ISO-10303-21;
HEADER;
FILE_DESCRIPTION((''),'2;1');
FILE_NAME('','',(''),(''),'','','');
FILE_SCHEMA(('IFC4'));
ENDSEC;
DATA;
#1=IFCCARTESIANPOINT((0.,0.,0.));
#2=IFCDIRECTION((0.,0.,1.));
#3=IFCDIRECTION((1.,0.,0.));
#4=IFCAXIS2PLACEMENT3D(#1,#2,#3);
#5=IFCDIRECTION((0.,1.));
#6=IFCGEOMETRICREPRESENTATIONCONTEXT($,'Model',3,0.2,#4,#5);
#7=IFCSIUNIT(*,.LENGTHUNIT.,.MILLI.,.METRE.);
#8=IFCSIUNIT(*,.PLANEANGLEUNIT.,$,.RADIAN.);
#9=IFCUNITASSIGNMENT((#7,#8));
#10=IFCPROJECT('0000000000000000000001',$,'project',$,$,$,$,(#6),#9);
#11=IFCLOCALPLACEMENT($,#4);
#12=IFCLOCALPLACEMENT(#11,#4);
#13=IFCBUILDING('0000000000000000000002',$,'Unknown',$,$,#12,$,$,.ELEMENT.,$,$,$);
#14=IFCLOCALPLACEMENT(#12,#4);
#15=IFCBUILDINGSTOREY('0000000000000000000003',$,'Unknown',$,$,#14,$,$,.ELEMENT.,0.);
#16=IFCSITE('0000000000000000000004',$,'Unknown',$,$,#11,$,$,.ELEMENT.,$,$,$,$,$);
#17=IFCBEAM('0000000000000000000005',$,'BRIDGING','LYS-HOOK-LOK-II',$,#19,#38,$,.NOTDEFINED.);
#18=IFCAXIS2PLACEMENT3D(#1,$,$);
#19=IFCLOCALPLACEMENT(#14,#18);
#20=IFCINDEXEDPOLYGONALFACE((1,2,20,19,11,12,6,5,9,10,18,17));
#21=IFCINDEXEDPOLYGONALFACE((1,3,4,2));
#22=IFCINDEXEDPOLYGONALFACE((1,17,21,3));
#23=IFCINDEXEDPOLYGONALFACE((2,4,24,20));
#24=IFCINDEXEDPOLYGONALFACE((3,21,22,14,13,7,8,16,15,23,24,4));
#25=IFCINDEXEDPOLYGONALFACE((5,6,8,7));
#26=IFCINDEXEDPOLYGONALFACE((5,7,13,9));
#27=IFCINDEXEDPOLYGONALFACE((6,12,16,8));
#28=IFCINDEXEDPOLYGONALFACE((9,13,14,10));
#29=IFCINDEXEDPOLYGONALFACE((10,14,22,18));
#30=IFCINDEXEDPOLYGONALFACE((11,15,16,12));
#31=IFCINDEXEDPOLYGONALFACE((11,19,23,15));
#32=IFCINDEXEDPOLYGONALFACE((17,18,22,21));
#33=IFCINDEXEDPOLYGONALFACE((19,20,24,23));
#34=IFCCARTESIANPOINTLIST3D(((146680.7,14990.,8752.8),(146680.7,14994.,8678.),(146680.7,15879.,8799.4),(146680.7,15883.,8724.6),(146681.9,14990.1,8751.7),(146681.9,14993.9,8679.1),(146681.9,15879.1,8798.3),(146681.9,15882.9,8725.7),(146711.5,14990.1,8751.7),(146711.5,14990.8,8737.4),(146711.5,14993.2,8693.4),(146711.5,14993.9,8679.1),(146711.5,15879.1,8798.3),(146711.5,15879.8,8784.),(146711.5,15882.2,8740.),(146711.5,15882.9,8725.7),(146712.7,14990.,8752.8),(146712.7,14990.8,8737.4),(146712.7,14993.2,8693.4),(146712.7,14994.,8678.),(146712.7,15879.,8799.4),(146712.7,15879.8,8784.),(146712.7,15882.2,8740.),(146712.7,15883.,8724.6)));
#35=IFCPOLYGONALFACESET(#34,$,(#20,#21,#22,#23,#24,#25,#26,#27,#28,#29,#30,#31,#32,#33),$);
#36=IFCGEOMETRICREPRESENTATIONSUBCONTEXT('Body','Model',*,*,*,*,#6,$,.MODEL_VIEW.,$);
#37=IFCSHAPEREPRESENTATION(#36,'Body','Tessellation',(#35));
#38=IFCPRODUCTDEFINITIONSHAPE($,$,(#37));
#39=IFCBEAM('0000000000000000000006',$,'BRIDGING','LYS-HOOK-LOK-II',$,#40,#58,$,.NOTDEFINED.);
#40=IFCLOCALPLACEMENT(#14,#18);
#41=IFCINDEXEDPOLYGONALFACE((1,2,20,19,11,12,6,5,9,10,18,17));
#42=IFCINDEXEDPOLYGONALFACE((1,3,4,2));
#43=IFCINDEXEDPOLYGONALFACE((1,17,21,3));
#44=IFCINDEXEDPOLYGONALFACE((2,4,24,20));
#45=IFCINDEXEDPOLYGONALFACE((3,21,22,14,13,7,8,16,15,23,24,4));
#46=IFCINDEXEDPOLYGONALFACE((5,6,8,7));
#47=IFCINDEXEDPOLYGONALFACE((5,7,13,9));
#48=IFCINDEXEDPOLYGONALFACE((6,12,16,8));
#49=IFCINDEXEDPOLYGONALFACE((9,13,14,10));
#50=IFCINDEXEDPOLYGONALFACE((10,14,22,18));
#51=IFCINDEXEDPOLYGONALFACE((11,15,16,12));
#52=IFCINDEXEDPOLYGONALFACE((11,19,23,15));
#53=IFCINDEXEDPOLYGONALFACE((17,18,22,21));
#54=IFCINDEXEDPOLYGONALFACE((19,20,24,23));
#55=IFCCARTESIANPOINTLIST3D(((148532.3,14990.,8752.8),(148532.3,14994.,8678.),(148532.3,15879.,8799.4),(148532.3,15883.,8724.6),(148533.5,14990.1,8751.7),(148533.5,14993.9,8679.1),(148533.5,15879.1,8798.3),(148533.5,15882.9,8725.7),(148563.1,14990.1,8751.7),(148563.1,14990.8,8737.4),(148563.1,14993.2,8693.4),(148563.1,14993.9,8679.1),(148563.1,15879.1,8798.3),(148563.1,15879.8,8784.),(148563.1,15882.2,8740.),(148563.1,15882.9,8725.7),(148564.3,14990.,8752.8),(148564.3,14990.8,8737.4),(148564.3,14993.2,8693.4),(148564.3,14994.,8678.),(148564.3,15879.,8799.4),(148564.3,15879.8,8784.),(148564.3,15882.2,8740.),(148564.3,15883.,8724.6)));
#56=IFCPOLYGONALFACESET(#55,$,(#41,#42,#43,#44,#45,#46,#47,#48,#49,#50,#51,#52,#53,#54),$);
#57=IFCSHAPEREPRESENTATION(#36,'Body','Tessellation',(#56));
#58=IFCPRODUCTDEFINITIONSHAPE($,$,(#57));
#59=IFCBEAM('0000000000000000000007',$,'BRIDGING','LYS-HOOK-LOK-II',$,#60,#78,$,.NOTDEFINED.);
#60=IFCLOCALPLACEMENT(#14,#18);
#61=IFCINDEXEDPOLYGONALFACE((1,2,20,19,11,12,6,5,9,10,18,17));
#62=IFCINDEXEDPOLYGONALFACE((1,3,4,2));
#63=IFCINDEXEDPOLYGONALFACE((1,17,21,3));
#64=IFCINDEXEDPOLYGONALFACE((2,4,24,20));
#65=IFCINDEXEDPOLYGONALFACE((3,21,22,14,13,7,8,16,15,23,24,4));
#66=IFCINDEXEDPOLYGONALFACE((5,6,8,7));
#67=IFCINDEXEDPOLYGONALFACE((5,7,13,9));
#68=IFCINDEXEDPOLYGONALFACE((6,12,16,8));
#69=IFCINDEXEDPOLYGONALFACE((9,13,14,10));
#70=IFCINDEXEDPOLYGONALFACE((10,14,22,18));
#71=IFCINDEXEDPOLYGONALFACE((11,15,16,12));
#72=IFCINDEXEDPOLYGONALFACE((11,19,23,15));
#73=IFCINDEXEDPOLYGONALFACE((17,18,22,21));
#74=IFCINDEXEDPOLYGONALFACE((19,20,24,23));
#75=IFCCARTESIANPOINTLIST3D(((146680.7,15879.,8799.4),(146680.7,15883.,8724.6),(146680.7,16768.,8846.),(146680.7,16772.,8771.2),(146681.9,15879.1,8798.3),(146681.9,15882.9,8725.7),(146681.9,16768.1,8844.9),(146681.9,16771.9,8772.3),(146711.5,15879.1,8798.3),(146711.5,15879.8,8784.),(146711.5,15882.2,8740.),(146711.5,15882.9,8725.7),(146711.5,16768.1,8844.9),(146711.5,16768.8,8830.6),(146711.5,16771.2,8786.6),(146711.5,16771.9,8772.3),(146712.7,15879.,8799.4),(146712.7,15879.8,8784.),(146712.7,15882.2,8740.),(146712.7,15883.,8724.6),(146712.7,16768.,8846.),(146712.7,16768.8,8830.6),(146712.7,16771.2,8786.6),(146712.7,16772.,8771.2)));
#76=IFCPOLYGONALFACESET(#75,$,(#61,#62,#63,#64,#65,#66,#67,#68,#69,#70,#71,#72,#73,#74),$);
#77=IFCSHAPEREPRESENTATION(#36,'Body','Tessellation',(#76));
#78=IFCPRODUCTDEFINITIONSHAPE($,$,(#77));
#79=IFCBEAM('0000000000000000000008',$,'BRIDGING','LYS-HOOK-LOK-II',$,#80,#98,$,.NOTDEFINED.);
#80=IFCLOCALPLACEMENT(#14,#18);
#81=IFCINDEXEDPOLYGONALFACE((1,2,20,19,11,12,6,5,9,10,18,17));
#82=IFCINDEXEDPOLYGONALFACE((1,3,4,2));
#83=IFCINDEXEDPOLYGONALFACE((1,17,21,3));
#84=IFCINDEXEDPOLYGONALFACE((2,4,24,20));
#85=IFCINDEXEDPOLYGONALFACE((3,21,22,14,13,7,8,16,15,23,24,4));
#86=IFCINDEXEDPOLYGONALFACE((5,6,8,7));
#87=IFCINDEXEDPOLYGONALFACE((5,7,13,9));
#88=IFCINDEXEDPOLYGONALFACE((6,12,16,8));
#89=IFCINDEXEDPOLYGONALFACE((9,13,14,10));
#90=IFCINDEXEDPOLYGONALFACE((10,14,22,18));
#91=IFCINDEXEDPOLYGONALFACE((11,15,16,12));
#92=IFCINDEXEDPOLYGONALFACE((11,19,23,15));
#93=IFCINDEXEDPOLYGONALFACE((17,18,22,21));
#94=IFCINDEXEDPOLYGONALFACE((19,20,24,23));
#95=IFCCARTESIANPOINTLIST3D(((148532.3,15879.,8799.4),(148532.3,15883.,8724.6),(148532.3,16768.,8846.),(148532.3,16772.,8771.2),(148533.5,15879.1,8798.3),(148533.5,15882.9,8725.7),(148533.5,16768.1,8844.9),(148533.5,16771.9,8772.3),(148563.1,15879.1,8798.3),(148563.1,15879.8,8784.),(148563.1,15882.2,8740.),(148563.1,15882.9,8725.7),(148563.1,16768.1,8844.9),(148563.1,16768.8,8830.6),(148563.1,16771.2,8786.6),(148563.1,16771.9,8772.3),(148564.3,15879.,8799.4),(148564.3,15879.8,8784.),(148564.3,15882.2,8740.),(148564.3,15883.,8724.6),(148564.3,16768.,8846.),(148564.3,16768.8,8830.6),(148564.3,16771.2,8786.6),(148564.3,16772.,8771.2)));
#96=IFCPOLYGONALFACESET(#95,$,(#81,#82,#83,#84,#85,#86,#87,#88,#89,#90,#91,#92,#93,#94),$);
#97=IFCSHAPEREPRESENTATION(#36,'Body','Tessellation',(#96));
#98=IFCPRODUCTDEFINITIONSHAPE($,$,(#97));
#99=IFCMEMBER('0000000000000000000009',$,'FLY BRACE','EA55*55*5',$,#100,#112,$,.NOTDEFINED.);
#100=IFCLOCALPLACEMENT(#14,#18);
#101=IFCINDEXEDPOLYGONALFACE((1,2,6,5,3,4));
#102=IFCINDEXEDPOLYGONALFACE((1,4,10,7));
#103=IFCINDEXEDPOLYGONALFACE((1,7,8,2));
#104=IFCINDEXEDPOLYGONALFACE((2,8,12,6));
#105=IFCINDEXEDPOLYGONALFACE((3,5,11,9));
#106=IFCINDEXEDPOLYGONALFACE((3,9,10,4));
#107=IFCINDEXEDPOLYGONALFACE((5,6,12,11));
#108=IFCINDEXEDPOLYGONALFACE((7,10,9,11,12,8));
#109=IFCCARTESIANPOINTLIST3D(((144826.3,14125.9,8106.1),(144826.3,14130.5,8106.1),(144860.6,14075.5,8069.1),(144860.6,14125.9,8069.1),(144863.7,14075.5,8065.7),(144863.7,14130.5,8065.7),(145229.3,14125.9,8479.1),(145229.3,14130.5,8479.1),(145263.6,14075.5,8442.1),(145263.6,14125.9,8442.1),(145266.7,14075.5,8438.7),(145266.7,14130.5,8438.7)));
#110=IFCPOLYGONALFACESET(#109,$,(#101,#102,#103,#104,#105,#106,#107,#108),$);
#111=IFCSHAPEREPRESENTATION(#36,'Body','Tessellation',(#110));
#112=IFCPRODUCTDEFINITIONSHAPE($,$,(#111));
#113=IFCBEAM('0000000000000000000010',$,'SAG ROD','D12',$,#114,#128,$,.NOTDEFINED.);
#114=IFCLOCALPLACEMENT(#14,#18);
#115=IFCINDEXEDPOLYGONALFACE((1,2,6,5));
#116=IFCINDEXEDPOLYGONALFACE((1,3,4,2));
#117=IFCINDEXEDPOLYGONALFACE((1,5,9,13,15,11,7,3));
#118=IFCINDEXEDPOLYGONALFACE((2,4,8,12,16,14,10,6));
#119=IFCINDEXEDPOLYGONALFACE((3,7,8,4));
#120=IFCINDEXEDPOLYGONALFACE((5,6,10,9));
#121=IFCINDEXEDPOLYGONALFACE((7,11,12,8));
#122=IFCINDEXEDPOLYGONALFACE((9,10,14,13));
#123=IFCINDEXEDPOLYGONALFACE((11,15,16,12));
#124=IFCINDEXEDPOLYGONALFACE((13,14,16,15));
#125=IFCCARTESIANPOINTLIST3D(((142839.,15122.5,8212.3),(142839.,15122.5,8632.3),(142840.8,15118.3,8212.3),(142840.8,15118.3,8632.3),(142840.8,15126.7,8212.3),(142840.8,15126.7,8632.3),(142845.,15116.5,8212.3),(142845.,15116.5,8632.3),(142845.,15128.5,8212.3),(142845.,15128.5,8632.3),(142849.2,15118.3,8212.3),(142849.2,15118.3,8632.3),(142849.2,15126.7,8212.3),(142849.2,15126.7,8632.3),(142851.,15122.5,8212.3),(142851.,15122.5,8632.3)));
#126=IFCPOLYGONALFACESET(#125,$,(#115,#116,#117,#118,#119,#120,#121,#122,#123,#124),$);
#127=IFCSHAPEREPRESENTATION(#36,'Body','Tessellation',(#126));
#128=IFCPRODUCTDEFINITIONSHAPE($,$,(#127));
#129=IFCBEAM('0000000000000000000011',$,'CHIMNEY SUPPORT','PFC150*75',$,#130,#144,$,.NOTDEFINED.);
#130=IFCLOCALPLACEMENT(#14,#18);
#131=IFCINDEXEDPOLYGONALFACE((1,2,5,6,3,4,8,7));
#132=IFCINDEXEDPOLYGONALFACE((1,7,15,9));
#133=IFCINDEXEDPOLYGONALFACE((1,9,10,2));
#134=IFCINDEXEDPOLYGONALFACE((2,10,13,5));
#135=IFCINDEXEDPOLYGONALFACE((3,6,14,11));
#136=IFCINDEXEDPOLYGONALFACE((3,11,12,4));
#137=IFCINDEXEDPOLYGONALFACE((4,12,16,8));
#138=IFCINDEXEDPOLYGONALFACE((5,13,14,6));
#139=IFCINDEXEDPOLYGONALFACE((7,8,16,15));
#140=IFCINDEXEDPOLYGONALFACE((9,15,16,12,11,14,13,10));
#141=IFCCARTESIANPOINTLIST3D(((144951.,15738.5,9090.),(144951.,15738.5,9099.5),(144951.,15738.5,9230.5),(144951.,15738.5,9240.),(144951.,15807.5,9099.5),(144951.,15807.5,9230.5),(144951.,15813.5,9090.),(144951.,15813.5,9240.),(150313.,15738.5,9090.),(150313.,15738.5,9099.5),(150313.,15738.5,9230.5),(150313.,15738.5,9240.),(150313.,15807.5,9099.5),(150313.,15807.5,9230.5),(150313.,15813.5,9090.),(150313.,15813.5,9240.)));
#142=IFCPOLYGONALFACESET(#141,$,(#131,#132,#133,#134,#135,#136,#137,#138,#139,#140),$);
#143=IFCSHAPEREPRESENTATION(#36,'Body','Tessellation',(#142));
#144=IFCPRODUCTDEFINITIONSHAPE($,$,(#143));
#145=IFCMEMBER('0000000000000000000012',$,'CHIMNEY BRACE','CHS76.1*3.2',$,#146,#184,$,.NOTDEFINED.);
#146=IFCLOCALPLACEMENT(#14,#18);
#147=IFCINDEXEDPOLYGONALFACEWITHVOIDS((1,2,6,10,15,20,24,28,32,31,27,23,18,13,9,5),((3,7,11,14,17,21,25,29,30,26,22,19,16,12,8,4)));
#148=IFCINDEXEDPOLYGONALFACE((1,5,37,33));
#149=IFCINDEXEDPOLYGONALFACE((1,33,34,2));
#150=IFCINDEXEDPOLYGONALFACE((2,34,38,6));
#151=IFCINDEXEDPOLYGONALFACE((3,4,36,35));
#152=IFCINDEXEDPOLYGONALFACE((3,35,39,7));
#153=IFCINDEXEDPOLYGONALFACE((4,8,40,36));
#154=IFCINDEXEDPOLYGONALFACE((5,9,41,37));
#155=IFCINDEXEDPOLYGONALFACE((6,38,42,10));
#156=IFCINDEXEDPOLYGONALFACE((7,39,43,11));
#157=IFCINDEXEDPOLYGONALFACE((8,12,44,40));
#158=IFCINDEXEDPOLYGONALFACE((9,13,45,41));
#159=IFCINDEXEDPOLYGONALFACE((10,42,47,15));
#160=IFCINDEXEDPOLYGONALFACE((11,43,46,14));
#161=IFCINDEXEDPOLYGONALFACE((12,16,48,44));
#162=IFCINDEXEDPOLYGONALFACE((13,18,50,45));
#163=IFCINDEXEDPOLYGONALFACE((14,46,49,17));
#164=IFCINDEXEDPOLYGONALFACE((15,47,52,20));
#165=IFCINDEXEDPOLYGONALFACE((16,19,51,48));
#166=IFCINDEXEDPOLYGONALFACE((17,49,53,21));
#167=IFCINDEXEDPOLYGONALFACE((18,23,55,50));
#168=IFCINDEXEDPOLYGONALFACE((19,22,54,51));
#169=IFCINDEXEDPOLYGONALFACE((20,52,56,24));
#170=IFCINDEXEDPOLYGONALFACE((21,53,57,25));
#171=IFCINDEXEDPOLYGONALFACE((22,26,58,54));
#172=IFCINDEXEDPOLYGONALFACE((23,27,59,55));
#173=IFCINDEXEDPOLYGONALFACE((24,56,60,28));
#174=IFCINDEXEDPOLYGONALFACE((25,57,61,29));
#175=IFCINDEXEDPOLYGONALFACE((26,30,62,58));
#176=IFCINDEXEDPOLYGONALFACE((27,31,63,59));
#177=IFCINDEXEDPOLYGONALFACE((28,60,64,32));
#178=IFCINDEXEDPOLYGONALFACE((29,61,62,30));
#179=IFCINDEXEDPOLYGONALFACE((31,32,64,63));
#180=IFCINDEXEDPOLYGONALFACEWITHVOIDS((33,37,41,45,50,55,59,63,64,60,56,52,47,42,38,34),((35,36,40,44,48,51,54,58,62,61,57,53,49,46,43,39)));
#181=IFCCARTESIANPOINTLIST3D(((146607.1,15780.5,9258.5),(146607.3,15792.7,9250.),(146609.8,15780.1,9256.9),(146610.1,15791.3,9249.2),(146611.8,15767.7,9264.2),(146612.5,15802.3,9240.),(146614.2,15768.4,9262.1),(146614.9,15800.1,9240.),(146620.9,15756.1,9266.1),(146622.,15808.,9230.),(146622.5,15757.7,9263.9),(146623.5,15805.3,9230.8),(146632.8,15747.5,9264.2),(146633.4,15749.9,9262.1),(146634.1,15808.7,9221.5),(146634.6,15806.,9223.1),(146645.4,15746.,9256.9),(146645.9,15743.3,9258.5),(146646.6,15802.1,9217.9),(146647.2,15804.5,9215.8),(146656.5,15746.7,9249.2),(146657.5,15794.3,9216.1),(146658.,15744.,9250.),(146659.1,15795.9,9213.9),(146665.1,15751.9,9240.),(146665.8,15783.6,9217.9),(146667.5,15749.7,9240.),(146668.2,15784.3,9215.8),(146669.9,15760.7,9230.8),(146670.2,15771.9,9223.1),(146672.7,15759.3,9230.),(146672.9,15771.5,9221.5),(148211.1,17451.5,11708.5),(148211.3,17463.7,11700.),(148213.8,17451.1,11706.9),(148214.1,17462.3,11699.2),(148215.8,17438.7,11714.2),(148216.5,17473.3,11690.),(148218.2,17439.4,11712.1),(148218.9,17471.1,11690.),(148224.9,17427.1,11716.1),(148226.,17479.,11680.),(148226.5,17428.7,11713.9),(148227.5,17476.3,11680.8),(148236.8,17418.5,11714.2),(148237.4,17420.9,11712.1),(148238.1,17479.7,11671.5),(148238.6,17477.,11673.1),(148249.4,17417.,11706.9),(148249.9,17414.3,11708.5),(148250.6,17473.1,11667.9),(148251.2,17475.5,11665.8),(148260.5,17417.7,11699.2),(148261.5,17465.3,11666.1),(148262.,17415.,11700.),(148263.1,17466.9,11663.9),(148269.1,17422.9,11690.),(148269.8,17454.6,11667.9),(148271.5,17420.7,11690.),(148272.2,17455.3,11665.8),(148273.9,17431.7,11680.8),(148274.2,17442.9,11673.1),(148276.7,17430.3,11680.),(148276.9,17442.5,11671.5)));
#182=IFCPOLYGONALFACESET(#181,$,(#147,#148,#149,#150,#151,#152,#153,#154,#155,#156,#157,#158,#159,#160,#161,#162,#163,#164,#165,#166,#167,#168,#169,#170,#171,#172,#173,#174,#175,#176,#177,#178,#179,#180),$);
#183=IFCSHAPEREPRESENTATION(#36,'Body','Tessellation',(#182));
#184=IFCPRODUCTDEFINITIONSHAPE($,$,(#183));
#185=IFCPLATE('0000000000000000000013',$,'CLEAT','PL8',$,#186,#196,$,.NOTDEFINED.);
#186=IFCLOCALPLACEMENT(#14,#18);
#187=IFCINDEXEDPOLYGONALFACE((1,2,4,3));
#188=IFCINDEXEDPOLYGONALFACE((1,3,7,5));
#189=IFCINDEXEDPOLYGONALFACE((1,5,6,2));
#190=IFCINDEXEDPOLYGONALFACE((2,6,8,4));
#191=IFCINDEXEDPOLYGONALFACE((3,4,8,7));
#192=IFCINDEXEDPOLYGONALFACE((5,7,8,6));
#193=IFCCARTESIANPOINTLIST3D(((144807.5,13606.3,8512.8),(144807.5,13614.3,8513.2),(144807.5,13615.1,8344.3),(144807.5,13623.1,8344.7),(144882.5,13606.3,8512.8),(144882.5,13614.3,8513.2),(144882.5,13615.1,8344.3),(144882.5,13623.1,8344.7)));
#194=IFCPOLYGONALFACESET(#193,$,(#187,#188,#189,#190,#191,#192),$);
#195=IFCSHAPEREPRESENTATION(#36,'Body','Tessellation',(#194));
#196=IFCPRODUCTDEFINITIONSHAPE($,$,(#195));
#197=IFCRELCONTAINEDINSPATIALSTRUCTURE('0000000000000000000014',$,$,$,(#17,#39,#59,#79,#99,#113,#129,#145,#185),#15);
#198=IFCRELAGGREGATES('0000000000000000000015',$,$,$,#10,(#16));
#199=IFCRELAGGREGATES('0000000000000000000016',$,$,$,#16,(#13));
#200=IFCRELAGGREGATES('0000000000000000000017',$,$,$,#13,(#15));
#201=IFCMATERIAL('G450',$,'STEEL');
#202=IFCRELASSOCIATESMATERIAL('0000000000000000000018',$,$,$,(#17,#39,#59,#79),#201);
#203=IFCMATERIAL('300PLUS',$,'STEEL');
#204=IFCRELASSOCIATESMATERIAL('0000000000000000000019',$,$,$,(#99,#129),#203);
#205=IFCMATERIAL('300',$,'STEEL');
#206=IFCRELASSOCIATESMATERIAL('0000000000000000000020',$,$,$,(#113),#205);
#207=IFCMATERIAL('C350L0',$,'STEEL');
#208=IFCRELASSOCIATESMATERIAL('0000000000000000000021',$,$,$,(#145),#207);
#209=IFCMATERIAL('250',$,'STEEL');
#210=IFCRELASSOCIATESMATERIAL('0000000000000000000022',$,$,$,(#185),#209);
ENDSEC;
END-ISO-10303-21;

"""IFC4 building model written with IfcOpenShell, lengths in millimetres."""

from ifc_helpers import new_model, si_unit, direction, frame, origin_with_axes, place, context, subcontext, project, spatial, line, indexed_curve, outline, extrude, material, element, save


model = new_model("IFC4")

# Units and contexts
model_context = context("Model", 3, precision=0.2, world=origin_with_axes(), true_north=direction((0.0, 1.0)))
body_context = subcontext(model_context, "Body", "Model", "MODEL_VIEW")
ifc_project = project(units=[si_unit("LENGTHUNIT", "METRE", prefix="MILLI"), si_unit("PLANEANGLEUNIT", "RADIAN")], contexts=[model_context])

# Site, building, storey
site_placement = place(None, origin_with_axes())
site = spatial("IfcSite", under=ifc_project, at=site_placement, Name="Unknown", CompositionType="ELEMENT")
building_placement = place(site_placement, origin_with_axes())
building = spatial("IfcBuilding", under=site, at=building_placement, Name="Unknown", CompositionType="ELEMENT")
storey_placement = place(building_placement, origin_with_axes())
storey = spatial("IfcBuildingStorey", under=building, at=storey_placement, Name="Unknown", CompositionType="ELEMENT", Elevation=0.0)

# Shared definitions
ifc_material_1 = material(Name="C350L0", Category="STEEL")

# Beams
ifc_material_2 = material(Name="G450", Category="STEEL")
for number, where, z_axis, x_axis, name in (
    (1, (146696.7, 14992.0, 8715.4), (1.0, 0.0, 0.0), (0.0, 0.998629, 0.052347), "BRIDGING"),
    (2, (148548.3, 14992.0, 8715.4), (1.0, 0.0, 0.0), (0.0, 0.998629, 0.052347), "BRIDGING"),
    (3, (146696.7, 15881.0, 8762.0), (1.0, 0.0, 0.0), (0.0, 0.998629, 0.052347), "BRIDGING"),
    (4, (148548.3, 15881.0, 8762.0), (1.0, 0.0, 0.0), (0.0, 0.998629, 0.052347), "BRIDGING"),
):
    element("IfcBeam", number, at=place(storey_placement, frame(where, z_axis=z_axis, x_axis=x_axis)), inside=storey, material=ifc_material_2, Name=name, Description="LYS-HOOK-LOK-II", PredefinedType="NOTDEFINED", context=body_context, shape_type="SolidModel", body=[
        extrude(outline(indexed_curve([(16.0, -37.5), (16.0, -22.0), (14.8, -22.0), (14.8, -36.3), (-14.8, -36.3), (-14.8, 36.3), (14.8, 36.3), (14.8, 22.0), (16.0, 22.0), (16.0, 37.5), (-16.0, 37.5), (-16.0, -37.5)], segments=[line(1, 2, 3, 4, 5, 6, 7, 8, 9, 10, 11, 12, 1)])), frame((0.0, 0.0, 0.0), z_axis=(-1.0, 0.0, 0.0), x_axis=(0.0, 0.0, 1.0)), (0.0, 0.0, -1.0), 890.2),
    ])

# Member
ifc_material_3 = material(Name="300PLUS", Category="STEEL")
member_1_placement = place(storey_placement, frame((145248.0, 14103.0, 8458.9), z_axis=(-0.679263, 0.0, 0.733895), x_axis=(-0.733895, 0.0, -0.679263)))
element("IfcMember", 5, at=member_1_placement, inside=storey, material=ifc_material_3, Name="FLY BRACE", Description="EA55*55*5", PredefinedType="NOTDEFINED", context=body_context, shape_type="SolidModel", body=[
    extrude(outline(indexed_curve([(-27.5, -27.5), (27.5, -27.5), (27.5, -22.9), (-22.9, -22.9), (-22.9, 27.5), (-27.5, 27.5)], segments=[line(1, 2, 3, 4, 5, 6, 1)])), frame((0.0, 0.0, 0.0), z_axis=(-1.0, 0.0, 0.0), x_axis=(0.0, 0.0, 1.0)), (0.0, 0.0, -1.0), 549.1),
])

# Beams
ifc_material_4 = material(Name="300", Category="STEEL")
beam_1_placement = place(storey_placement, frame((142845.0, 15122.5, 8632.3), z_axis=(1.0, 0.0, 0.0), x_axis=(0.0, 0.0, -1.0)))
element("IfcBeam", 6, at=beam_1_placement, inside=storey, material=ifc_material_4, Name="SAG ROD", Description="D12", PredefinedType="NOTDEFINED", context=body_context, shape_type="SolidModel", body=[
    extrude(outline(indexed_curve([(6.0, 0.0), (4.2, 4.2), (0.0, 6.0), (-4.2, 4.2), (-6.0, 0.0), (-4.2, -4.2), (0.0, -6.0), (4.2, -4.2)], segments=[line(1, 2, 3, 4, 5, 6, 7, 8, 1)])), frame((0.0, 0.0, 0.0), z_axis=(-1.0, 0.0, 0.0), x_axis=(0.0, 0.0, 1.0)), (0.0, 0.0, -1.0), 420.0),
])
beam_2_placement = place(storey_placement, frame((144951.0, 15776.0, 9165.0), z_axis=(0.0, -1.0, 0.0), x_axis=(1.0, 0.0, 0.0)))
element("IfcBeam", 7, at=beam_2_placement, inside=storey, material=ifc_material_3, Name="CHIMNEY SUPPORT", Description="PFC150*75", PredefinedType="NOTDEFINED", context=body_context, shape_type="SolidModel", body=[
    extrude(outline(indexed_curve([(-37.5, -75.0), (37.5, -75.0), (37.5, -65.5), (-31.5, -65.5), (-31.5, 65.5), (37.5, 65.5), (37.5, 75.0), (-37.5, 75.0)], segments=[line(1, 2, 3, 4, 5, 6, 7, 8, 1)])), frame((0.0, 0.0, 0.0), z_axis=(-1.0, 0.0, 0.0), x_axis=(0.0, 0.0, 1.0)), (0.0, 0.0, -1.0), 5362.0),
])

# Member
member_2_placement = place(storey_placement, frame((146640.0, 15776.0, 9240.0), z_axis=(-0.503211, -0.52423, 0.686995), x_axis=(0.475741, 0.495613, 0.726662)))
element("IfcMember", 8, at=member_2_placement, inside=storey, material=ifc_material_1, Name="CHIMNEY BRACE", Description="CHS76.1*3.2", PredefinedType="NOTDEFINED", context=body_context, shape_type="SolidModel", body=[
    extrude(outline(indexed_curve([(38.0, 0.0), (35.2, 14.6), (26.9, 26.9), (14.6, 35.2), (0.0, 38.0), (-14.6, 35.2), (-26.9, 26.9), (-35.2, 14.6), (-38.0, 0.0), (-35.2, -14.6), (-26.9, -26.9), (-14.6, -35.2), (0.0, -38.0), (14.6, -35.2), (26.9, -26.9), (35.2, -14.6)], segments=[line(1, 2, 3, 4, 5, 6, 7, 8, 9, 10, 11, 12, 13, 14, 15, 16, 1)]), holes=[indexed_curve([(34.9, 0.0), (32.2, -13.3), (24.6, -24.6), (13.3, -32.2), (0.0, -34.9), (-13.3, -32.2), (-24.6, -24.6), (-32.2, -13.3), (-34.9, 0.0), (-32.2, 13.3), (-24.6, 24.6), (-13.3, 32.2), (0.0, 34.9), (13.3, 32.2), (24.6, 24.6), (32.2, 13.3)], segments=[line(1, 2, 3, 4, 5, 6, 7, 8, 9, 10, 11, 12, 13, 14, 15, 16, 1)])]), frame((0.0, 0.0, 0.0), z_axis=(-1.0, 0.0, 0.0), x_axis=(0.0, 0.0, 1.0)), (0.0, 0.0, -1.0), 3371.6),
])

# Plate
ifc_material_5 = material(Name="250", Category="STEEL")
plate_1_placement = place(storey_placement, frame((144807.5, 13610.3, 8513.0), z_axis=(0.0, 0.998639, 0.052154), x_axis=(1.0, 0.0, 0.0)))
element("IfcPlate", 9, at=plate_1_placement, inside=storey, material=ifc_material_5, Name="CLEAT", Description="PL8", PredefinedType="NOTDEFINED", context=body_context, shape_type="SolidModel", body=[
    extrude(outline(indexed_curve([(0.0, 0.0), (75.0, 0.0), (75.0, 168.7), (0.0, 168.7)], segments=[line(1, 2, 3, 4, 1)])), frame((0.0, 0.0, 4.0), z_axis=(0.0, 0.0, 1.0), x_axis=(1.0, 0.0, 0.0)), (0.0, 0.0, -1.0), 8.0),
])

save(model, "model.ifc")
